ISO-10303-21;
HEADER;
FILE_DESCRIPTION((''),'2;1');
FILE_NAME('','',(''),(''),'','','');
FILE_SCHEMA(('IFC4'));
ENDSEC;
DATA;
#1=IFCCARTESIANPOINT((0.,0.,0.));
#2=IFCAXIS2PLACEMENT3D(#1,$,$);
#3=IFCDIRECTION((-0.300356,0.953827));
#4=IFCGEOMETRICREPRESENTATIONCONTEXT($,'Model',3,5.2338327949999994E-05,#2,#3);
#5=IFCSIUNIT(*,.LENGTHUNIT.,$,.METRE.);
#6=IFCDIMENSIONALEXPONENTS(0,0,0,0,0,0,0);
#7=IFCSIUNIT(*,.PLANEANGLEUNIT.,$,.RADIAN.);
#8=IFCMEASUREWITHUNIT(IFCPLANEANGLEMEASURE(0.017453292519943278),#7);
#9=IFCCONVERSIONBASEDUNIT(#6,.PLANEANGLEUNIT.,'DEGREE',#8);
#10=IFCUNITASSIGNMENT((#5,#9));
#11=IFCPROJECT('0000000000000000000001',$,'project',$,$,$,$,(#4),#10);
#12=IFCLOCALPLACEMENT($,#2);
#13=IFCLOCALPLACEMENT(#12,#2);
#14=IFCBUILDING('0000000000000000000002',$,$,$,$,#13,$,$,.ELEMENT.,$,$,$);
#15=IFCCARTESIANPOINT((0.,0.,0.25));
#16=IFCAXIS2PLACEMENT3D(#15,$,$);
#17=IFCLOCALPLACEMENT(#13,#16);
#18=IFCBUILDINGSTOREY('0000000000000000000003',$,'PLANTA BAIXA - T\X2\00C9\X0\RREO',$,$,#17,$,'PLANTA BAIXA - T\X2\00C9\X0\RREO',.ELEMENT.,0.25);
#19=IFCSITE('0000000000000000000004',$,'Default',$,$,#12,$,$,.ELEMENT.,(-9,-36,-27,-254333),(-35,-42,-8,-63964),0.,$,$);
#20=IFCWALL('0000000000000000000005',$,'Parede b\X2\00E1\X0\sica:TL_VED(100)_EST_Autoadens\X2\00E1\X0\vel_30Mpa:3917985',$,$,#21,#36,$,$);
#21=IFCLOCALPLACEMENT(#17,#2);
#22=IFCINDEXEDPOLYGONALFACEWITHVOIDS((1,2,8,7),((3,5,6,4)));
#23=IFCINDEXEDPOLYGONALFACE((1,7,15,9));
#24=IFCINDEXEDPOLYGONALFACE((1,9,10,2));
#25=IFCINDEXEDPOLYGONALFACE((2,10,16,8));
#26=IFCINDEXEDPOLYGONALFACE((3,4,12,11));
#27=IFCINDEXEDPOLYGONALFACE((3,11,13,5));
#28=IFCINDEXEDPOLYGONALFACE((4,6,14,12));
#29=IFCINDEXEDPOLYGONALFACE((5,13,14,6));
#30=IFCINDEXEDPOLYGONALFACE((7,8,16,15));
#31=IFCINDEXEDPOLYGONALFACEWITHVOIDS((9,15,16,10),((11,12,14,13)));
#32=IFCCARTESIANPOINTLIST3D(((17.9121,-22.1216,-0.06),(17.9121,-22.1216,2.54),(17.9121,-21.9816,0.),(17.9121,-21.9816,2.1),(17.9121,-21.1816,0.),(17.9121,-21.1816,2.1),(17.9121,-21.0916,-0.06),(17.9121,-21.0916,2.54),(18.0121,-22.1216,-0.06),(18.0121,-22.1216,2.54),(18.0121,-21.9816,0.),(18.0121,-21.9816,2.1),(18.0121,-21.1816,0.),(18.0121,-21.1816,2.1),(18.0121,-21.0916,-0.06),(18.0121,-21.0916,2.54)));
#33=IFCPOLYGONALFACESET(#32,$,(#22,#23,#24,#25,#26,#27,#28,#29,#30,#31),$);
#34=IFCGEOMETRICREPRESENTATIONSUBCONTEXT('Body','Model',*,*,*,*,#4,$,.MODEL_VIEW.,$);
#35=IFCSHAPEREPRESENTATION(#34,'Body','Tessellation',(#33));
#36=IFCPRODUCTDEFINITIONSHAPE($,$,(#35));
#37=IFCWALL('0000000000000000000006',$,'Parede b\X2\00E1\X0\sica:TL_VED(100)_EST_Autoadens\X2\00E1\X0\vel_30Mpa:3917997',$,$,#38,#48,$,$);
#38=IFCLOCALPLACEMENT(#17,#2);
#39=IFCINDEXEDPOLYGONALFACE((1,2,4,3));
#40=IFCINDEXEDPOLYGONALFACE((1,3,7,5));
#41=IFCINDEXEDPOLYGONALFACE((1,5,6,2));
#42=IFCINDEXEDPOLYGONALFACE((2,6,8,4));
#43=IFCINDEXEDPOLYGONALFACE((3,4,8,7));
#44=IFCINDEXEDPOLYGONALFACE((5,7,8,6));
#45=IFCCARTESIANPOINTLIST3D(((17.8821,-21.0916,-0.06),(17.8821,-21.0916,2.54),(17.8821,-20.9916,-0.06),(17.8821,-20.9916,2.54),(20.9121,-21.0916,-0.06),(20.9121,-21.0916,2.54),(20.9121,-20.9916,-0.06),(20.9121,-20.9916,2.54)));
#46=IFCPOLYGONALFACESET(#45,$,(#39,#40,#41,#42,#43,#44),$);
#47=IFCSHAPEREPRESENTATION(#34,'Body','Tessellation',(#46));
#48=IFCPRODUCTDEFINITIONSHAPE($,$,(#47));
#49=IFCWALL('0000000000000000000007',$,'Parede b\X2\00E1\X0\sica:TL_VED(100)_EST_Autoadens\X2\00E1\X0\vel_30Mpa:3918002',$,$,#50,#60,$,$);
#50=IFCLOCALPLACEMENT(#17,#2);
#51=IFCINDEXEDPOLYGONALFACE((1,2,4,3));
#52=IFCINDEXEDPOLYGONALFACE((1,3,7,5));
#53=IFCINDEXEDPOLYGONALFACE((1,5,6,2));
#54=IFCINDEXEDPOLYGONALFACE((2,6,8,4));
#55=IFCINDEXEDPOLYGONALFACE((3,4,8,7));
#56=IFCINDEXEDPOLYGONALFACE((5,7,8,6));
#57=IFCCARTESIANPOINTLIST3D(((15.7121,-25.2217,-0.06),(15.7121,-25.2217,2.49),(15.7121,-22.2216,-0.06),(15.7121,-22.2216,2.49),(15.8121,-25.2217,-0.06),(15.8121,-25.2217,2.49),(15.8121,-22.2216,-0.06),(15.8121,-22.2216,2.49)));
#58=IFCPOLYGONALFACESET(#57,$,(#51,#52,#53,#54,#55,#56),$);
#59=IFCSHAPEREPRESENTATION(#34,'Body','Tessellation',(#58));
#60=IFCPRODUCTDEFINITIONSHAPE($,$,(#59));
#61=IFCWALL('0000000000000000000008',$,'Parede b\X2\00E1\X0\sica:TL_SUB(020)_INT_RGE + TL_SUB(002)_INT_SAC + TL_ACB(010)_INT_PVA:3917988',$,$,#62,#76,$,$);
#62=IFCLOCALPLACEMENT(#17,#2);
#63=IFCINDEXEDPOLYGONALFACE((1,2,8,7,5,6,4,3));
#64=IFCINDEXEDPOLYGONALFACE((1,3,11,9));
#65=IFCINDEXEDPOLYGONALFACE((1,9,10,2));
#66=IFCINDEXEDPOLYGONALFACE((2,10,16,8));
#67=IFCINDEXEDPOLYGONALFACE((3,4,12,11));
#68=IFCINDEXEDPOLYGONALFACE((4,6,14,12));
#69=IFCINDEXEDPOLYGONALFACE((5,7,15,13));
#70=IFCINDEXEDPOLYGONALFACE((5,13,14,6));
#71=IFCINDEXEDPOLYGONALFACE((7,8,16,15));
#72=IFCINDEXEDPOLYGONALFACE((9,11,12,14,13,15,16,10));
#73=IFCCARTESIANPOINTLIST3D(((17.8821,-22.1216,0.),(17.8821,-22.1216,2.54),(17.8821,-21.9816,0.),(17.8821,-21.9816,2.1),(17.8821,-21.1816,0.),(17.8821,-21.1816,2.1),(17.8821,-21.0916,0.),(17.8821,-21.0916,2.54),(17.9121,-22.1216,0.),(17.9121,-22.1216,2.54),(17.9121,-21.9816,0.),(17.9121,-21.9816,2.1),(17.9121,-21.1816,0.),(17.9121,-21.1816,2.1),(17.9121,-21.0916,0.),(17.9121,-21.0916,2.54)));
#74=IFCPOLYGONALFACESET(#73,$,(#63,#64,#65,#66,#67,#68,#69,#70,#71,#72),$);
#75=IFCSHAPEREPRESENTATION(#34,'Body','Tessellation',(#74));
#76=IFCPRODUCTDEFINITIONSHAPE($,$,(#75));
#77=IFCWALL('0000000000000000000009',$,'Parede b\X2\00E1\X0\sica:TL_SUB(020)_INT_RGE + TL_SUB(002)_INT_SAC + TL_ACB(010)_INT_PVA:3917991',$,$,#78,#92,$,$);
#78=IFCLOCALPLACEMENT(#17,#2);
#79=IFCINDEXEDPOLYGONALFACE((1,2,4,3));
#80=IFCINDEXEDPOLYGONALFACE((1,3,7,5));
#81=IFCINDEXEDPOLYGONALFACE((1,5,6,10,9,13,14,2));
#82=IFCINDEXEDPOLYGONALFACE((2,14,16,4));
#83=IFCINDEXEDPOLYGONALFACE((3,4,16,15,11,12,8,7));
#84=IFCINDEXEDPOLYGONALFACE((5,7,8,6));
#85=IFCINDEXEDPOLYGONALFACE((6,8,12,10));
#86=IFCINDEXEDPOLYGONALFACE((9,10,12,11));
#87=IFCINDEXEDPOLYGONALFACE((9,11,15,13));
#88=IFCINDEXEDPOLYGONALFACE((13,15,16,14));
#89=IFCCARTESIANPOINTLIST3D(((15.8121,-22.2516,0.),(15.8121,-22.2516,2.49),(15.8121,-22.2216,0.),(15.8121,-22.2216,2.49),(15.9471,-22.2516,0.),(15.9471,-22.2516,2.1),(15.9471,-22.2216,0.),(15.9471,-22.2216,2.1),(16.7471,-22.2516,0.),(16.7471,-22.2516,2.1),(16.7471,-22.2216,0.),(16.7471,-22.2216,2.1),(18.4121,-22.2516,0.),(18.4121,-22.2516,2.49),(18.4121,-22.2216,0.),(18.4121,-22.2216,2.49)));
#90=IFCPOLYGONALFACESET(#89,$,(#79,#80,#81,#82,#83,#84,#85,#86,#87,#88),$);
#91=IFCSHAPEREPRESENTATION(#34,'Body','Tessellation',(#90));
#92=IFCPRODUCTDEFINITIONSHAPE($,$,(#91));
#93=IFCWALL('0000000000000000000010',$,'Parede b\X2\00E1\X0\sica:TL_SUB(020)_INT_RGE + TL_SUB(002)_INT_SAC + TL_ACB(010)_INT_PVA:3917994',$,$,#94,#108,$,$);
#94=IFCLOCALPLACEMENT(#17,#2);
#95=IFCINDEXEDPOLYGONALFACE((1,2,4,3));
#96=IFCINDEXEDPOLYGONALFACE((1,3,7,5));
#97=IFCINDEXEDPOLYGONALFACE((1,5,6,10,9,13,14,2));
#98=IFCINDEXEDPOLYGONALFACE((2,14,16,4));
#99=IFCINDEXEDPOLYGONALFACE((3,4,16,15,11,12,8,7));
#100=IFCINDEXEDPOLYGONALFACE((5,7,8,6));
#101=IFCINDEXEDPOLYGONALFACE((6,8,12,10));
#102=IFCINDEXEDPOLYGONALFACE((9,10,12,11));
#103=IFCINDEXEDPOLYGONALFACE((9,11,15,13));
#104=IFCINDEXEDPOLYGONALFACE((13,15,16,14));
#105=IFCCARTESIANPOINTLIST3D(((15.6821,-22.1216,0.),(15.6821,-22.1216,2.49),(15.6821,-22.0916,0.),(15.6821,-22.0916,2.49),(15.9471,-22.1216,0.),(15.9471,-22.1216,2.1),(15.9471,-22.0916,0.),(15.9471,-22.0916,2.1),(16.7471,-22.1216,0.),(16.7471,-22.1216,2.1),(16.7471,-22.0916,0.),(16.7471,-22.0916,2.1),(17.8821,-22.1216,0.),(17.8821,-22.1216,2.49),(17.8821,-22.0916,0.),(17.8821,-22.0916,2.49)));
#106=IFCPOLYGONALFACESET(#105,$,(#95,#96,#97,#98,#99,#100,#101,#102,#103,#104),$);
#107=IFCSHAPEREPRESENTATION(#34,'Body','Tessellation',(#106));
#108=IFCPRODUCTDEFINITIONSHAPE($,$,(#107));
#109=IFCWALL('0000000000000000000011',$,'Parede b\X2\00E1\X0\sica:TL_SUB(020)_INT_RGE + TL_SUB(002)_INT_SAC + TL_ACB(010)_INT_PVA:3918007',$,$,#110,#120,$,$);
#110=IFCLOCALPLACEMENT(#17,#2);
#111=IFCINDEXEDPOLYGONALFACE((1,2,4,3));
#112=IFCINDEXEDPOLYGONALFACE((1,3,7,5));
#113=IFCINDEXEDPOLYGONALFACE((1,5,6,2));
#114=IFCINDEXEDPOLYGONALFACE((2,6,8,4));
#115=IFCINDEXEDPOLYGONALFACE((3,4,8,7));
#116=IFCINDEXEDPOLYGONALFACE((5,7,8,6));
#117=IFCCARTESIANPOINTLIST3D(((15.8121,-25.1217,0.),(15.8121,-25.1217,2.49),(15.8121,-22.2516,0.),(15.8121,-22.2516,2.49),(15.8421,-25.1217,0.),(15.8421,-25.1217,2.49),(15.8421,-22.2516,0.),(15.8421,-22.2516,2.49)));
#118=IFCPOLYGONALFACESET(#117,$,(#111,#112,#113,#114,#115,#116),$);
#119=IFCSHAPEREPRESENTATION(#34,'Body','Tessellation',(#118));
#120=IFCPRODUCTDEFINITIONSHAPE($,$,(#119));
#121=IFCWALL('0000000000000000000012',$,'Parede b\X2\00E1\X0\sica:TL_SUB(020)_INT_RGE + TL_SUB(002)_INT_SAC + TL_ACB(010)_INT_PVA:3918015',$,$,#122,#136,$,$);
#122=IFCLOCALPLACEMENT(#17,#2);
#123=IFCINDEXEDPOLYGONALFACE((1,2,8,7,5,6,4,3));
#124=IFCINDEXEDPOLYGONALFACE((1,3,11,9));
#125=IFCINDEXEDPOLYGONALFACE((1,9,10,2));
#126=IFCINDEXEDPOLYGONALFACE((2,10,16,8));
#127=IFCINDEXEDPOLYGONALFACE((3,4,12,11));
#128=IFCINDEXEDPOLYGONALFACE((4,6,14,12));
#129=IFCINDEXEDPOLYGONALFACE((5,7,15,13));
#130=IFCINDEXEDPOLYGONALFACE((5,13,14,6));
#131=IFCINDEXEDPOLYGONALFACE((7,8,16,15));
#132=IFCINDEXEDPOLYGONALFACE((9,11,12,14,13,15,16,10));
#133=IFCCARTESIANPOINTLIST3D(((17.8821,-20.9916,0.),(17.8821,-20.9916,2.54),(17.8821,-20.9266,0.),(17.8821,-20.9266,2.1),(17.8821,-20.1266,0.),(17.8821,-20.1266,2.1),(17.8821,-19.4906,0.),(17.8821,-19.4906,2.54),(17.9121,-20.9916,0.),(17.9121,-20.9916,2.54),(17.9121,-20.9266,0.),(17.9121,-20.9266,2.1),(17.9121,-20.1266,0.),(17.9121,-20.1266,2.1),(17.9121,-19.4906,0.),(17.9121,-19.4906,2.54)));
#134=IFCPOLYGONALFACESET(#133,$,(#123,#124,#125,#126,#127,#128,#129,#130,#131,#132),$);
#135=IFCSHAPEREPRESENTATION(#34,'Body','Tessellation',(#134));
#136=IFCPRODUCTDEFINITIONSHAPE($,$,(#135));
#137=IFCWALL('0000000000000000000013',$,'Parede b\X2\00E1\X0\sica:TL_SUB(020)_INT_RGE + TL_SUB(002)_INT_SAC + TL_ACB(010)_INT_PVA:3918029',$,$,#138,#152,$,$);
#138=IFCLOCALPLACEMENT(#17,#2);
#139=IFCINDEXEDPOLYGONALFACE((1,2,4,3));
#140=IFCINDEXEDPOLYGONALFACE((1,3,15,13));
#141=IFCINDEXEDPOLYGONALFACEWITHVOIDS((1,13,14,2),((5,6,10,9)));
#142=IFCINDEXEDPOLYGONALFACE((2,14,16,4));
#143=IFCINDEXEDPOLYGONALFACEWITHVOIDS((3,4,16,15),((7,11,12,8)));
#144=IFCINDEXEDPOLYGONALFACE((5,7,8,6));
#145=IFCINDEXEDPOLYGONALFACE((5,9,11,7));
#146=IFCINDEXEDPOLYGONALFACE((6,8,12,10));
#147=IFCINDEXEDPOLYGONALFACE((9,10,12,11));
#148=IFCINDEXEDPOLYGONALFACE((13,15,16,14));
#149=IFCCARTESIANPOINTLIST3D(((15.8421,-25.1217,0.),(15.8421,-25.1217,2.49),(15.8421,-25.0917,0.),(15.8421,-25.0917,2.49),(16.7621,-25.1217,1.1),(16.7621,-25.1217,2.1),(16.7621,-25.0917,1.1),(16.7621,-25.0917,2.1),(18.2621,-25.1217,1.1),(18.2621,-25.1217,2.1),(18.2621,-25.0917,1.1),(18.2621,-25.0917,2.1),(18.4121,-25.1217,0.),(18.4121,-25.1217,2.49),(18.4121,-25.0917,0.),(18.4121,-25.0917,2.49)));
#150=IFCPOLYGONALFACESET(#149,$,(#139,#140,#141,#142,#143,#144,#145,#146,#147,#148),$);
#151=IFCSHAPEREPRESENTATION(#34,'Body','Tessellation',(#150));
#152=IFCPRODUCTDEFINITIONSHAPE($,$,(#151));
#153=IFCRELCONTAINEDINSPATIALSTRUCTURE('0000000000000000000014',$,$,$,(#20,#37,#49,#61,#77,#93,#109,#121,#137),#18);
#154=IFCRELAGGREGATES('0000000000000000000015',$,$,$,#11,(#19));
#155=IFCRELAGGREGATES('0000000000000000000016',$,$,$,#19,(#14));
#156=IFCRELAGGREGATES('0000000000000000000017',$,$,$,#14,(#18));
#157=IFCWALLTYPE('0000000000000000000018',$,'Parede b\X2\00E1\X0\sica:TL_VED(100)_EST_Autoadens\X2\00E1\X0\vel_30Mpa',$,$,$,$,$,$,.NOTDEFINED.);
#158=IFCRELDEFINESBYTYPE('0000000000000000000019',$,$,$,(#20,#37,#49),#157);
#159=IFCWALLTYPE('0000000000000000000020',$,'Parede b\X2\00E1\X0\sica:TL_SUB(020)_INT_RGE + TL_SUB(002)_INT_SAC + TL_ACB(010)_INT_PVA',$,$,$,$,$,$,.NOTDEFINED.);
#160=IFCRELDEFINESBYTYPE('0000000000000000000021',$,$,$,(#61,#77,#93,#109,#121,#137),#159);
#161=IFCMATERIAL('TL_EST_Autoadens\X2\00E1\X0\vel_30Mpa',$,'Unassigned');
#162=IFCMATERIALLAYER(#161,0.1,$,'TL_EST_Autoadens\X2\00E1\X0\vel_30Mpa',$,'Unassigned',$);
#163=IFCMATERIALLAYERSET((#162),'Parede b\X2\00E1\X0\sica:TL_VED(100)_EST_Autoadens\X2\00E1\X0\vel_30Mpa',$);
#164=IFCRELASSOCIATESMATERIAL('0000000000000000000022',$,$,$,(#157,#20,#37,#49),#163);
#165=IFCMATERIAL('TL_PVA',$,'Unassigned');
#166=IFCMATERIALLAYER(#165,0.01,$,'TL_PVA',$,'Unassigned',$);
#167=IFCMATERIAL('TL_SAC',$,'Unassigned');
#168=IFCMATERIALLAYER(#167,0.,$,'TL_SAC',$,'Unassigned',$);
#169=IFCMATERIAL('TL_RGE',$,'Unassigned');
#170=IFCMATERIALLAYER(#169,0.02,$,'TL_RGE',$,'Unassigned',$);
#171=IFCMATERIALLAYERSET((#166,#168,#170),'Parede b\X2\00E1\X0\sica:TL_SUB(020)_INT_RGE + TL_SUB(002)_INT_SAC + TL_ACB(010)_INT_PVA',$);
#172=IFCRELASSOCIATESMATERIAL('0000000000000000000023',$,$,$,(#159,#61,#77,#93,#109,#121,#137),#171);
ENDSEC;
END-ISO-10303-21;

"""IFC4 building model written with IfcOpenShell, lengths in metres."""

from ifc_helpers import new_model, entity, si_unit, converted_unit, direction, frame, frame_2d, origin, place, context, subcontext, project, spatial, rectangle, extrude, material, layer, layer_set, layer_usage, type_object, element, save


model = new_model("IFC4")

# Units and contexts
model_context = context("Model", 3, precision=5.2338327949999994e-05, world=origin(), true_north=direction((-0.300356, 0.953827)))
body_context = subcontext(model_context, "Body", "Model", "MODEL_VIEW")
ifc_project = project(units=[si_unit("LENGTHUNIT", "METRE"), converted_unit("PLANEANGLEUNIT", "DEGREE", entity("IfcPlaneAngleMeasure", 0.017453292519943278), si_unit("PLANEANGLEUNIT", "RADIAN"), dimensions=[0, 0, 0, 0, 0, 0, 0])], contexts=[model_context])

# Site, building, storey
site_placement = place(None, origin())
site = spatial("IfcSite", under=ifc_project, at=site_placement, Name="Default", CompositionType="ELEMENT", RefLatitude=(-9, -36, -27, -254333), RefLongitude=(-35, -42, -8, -63964), RefElevation=0.0)
building_placement = place(site_placement, origin())
building = spatial("IfcBuilding", under=site, at=building_placement, CompositionType="ELEMENT")
storey_placement = place(building_placement, frame((0.0, 0.0, 0.25)))
storey = spatial("IfcBuildingStorey", under=building, at=storey_placement, Name="PLANTA BAIXA - TÉRREO", LongName="PLANTA BAIXA - TÉRREO", CompositionType="ELEMENT", Elevation=0.25)

# Wall, opening
ifc_material_1 = material(Name="TL_EST_Autoadensável_30Mpa", Category="Unassigned")
ifc_layer_1 = layer(ifc_material_1, 0.1, Name="TL_EST_Autoadensável_30Mpa", Category="Unassigned")
ifc_layer_set_1 = layer_set([ifc_layer_1], Name="Parede básica:TL_VED(100)_EST_Autoadensável_30Mpa")
ifc_layer_usage_1 = layer_usage(ifc_layer_set_1, "AXIS2", "POSITIVE", -0.05)
wall_type_1 = type_object("IfcWallType", Name="Parede básica:TL_VED(100)_EST_Autoadensável_30Mpa", PredefinedType="NOTDEFINED", material=ifc_layer_set_1)
wall_1_placement = place(storey_placement, frame((17.9621, -22.1216, -0.06), z_axis=(0.0, 0.0, 1.0), x_axis=(0.0, 1.0, 0.0)))
wall_1 = element("IfcWall", 1, at=wall_1_placement, inside=storey, type_object=wall_type_1, material=ifc_layer_usage_1, Name="Parede básica:TL_VED(100)_EST_Autoadensável_30Mpa:3917985", context=body_context, shape_type="SweptSolid", body=[
    extrude(rectangle(XDim=1.03, YDim=0.1, at=frame_2d((0.515, 0.0), x_axis=(-1.0, 0.0))), origin(), (0.0, 0.0, 1.0), 2.6),
])
opening_1_placement = place(wall_1_placement, frame((0.94, 0.05, 0.06)))
element("IfcOpeningElement", 2, at=opening_1_placement, cuts=wall_1, PredefinedType="OPENING", context=body_context, shape_type="SweptSolid", body=[
    extrude(rectangle(XDim=2.1, YDim=0.8, at=frame_2d((1.05, 0.4), x_axis=(1.0, 0.0))), frame((0.0, 0.0, 0.0), z_axis=(0.0, -1.0, 0.0), x_axis=(0.0, 0.0, 1.0)), (0.0, 0.0, 1.0), 0.1),
])

# Wall
ifc_layer_usage_2 = layer_usage(ifc_layer_set_1, "AXIS2", "NEGATIVE", 0.05)
wall_2_placement = place(storey_placement, frame((17.8821, -21.0416, -0.06)))
element("IfcWall", 3, at=wall_2_placement, inside=storey, type_object=wall_type_1, material=ifc_layer_usage_2, Name="Parede básica:TL_VED(100)_EST_Autoadensável_30Mpa:3917997", context=body_context, shape_type="SweptSolid", body=[
    extrude(rectangle(XDim=3.03, YDim=0.1, at=frame_2d((1.515, 0.0), x_axis=(-1.0, 0.0))), origin(), (0.0, 0.0, 1.0), 2.6),
])

# Walls, openings
ifc_layer_usage_3 = layer_usage(ifc_layer_set_1, "AXIS2", "NEGATIVE", 0.05)
wall_3_placement = place(storey_placement, frame((15.7621, -25.2217, -0.06), z_axis=(0.0, 0.0, 1.0), x_axis=(0.0, 1.0, 0.0)))
wall_3 = element("IfcWall", 4, at=wall_3_placement, inside=storey, type_object=wall_type_1, material=ifc_layer_usage_3, Name="Parede básica:TL_VED(100)_EST_Autoadensável_30Mpa:3918002", context=body_context, shape_type="SweptSolid", body=[
    extrude(rectangle(XDim=3.0001, YDim=0.1, at=frame_2d((1.5001, 0.0), x_axis=(-1.0, 0.0))), origin(), (0.0, 0.0, 1.0), 2.55),
])
opening_2_placement = place(wall_3_placement, frame((25.2217, 15.7621, 0.06)))
element("IfcOpeningElement", 5, at=opening_2_placement, cuts=wall_3, PredefinedType="OPENING", context=body_context, shape_type="SweptSolid", body=[
    extrude(rectangle(XDim=2.1, YDim=0.1, at=frame_2d((0.0, 0.0), x_axis=(0.0, 1.0))), frame((-24.2717, -15.7121, 1.05), z_axis=(0.0, 1.0, 0.0), x_axis=(1.0, 0.0, 0.0)), (0.0, 0.0, 1.0), 2.4),
])
ifc_material_2 = material(Name="TL_PVA", Category="Unassigned")
ifc_layer_2 = layer(ifc_material_2, 0.01, Name="TL_PVA", Category="Unassigned")
ifc_material_3 = material(Name="TL_SAC", Category="Unassigned")
ifc_layer_3 = layer(ifc_material_3, 0.0, Name="TL_SAC", Category="Unassigned")
ifc_material_4 = material(Name="TL_RGE", Category="Unassigned")
ifc_layer_4 = layer(ifc_material_4, 0.02, Name="TL_RGE", Category="Unassigned")
ifc_layer_set_2 = layer_set([ifc_layer_2, ifc_layer_3, ifc_layer_4], Name="Parede básica:TL_SUB(020)_INT_RGE + TL_SUB(002)_INT_SAC + TL_ACB(010)_INT_PVA")
ifc_layer_usage_4 = layer_usage(ifc_layer_set_2, "AXIS2", "POSITIVE", -0.015)
wall_type_2 = type_object("IfcWallType", Name="Parede básica:TL_SUB(020)_INT_RGE + TL_SUB(002)_INT_SAC + TL_ACB(010)_INT_PVA", PredefinedType="NOTDEFINED", material=ifc_layer_set_2)
wall_4_placement = place(storey_placement, frame((17.8971, -21.0916, 0.0), z_axis=(0.0, 0.0, 1.0), x_axis=(0.0, -1.0, 0.0)))
wall_4 = element("IfcWall", 6, at=wall_4_placement, inside=storey, type_object=wall_type_2, material=ifc_layer_usage_4, Name="Parede básica:TL_SUB(020)_INT_RGE + TL_SUB(002)_INT_SAC + TL_ACB(010)_INT_PVA:3917988", context=body_context, shape_type="SweptSolid", body=[
    extrude(rectangle(XDim=1.03, YDim=0.03, at=frame_2d((0.515, 0.0), x_axis=(-1.0, 0.0))), origin(), (0.0, 0.0, 1.0), 2.54),
])
opening_3_placement = place(wall_4_placement, frame((-21.0916, -17.8971, 0.0)))
element("IfcOpeningElement", 7, at=opening_3_placement, cuts=wall_4, PredefinedType="OPENING", context=body_context, shape_type="SweptSolid", body=[
    extrude(rectangle(XDim=2.1, YDim=0.8, at=frame_2d((0.0, 0.0), x_axis=(1.0, 0.0))), frame((21.5816, 16.3881, 1.05), z_axis=(0.0, 1.0, 0.0), x_axis=(0.0, 0.0, 1.0)), (0.0, 0.0, 1.0), 3.048),
])
ifc_layer_usage_5 = layer_usage(ifc_layer_set_2, "AXIS2", "POSITIVE", -0.015)
wall_5_placement = place(storey_placement, frame((15.8121, -22.2366, 0.0)))
wall_5 = element("IfcWall", 8, at=wall_5_placement, inside=storey, type_object=wall_type_2, material=ifc_layer_usage_5, Name="Parede básica:TL_SUB(020)_INT_RGE + TL_SUB(002)_INT_SAC + TL_ACB(010)_INT_PVA:3917991", context=body_context, shape_type="SweptSolid", body=[
    extrude(rectangle(XDim=2.6, YDim=0.03, at=frame_2d((1.3, 0.0), x_axis=(-1.0, 0.0))), origin(), (0.0, 0.0, 1.0), 2.49),
])
opening_4_placement = place(wall_5_placement, frame((-15.8121, 22.2366, 0.0)))
element("IfcOpeningElement", 9, at=opening_4_placement, cuts=wall_5, PredefinedType="OPENING", context=body_context, shape_type="SweptSolid", body=[
    extrude(rectangle(XDim=2.1, YDim=0.8, at=frame_2d((0.0, 0.0), x_axis=(1.0, 0.0))), frame((16.3471, -23.6456, 1.05), z_axis=(0.0, 1.0, 0.0), x_axis=(0.0, 0.0, 1.0)), (0.0, 0.0, 1.0), 3.048),
])
ifc_layer_usage_6 = layer_usage(ifc_layer_set_2, "AXIS2", "POSITIVE", -0.015)
wall_6_placement = place(storey_placement, frame((17.8821, -22.1066, 0.0), z_axis=(0.0, 0.0, 1.0), x_axis=(-1.0, 0.0, 0.0)))
wall_6 = element("IfcWall", 10, at=wall_6_placement, inside=storey, type_object=wall_type_2, material=ifc_layer_usage_6, Name="Parede básica:TL_SUB(020)_INT_RGE + TL_SUB(002)_INT_SAC + TL_ACB(010)_INT_PVA:3917994", context=body_context, shape_type="SweptSolid", body=[
    extrude(rectangle(XDim=2.2, YDim=0.03, at=frame_2d((1.1, 0.0), x_axis=(1.0, 0.0))), origin(), (0.0, 0.0, 1.0), 2.49),
])
opening_5_placement = place(wall_6_placement, frame((17.8821, -22.1066, 0.0)))
element("IfcOpeningElement", 11, at=opening_5_placement, cuts=wall_6, PredefinedType="OPENING", context=body_context, shape_type="SweptSolid", body=[
    extrude(rectangle(XDim=2.1, YDim=0.8, at=frame_2d((0.0, 0.0), x_axis=(0.0, 1.0))), frame((-16.3471, 20.5976, 1.05), z_axis=(0.0, 1.0, 0.0), x_axis=(-1.0, 0.0, 0.0)), (0.0, 0.0, 1.0), 3.048),
])

# Wall
ifc_layer_usage_7 = layer_usage(ifc_layer_set_2, "AXIS2", "NEGATIVE", 0.015)
wall_7_placement = place(storey_placement, frame((15.8271, -22.2516, 0.0), z_axis=(0.0, 0.0, 1.0), x_axis=(0.0, -1.0, 0.0)))
element("IfcWall", 12, at=wall_7_placement, inside=storey, type_object=wall_type_2, material=ifc_layer_usage_7, Name="Parede básica:TL_SUB(020)_INT_RGE + TL_SUB(002)_INT_SAC + TL_ACB(010)_INT_PVA:3918007", context=body_context, shape_type="SweptSolid", body=[
    extrude(rectangle(XDim=2.8701, YDim=0.03, at=frame_2d((1.4351, 0.0), x_axis=(-1.0, 0.0))), origin(), (0.0, 0.0, 1.0), 2.49),
])

# Walls, openings
ifc_layer_usage_8 = layer_usage(ifc_layer_set_2, "AXIS2", "NEGATIVE", 0.015)
wall_8_placement = place(storey_placement, frame((17.8971, -20.9916, 0.0), z_axis=(0.0, 0.0, 1.0), x_axis=(0.0, 1.0, 0.0)))
wall_8 = element("IfcWall", 13, at=wall_8_placement, inside=storey, type_object=wall_type_2, material=ifc_layer_usage_8, Name="Parede básica:TL_SUB(020)_INT_RGE + TL_SUB(002)_INT_SAC + TL_ACB(010)_INT_PVA:3918015", context=body_context, shape_type="SweptSolid", body=[
    extrude(rectangle(XDim=1.501, YDim=0.03, at=frame_2d((0.7505, 0.0), x_axis=(-1.0, 0.0))), origin(), (0.0, 0.0, 1.0), 2.54),
])
opening_6_placement = place(wall_8_placement, frame((0.865, 0.015, 0.0)))
element("IfcOpeningElement", 14, at=opening_6_placement, cuts=wall_8, PredefinedType="OPENING", context=body_context, shape_type="SweptSolid", body=[
    extrude(rectangle(XDim=2.1, YDim=0.8, at=frame_2d((1.05, 0.4), x_axis=(1.0, 0.0))), frame((0.0, 0.0, 0.0), z_axis=(0.0, -1.0, 0.0), x_axis=(0.0, 0.0, 1.0)), (0.0, 0.0, 1.0), 0.03),
])
ifc_layer_usage_9 = layer_usage(ifc_layer_set_2, "AXIS2", "NEGATIVE", 0.015)
wall_9_placement = place(storey_placement, frame((15.8421, -25.1067, 0.0)))
wall_9 = element("IfcWall", 15, at=wall_9_placement, inside=storey, type_object=wall_type_2, material=ifc_layer_usage_9, Name="Parede básica:TL_SUB(020)_INT_RGE + TL_SUB(002)_INT_SAC + TL_ACB(010)_INT_PVA:3918029", context=body_context, shape_type="SweptSolid", body=[
    extrude(rectangle(XDim=2.57, YDim=0.03, at=frame_2d((1.285, 0.0), x_axis=(-1.0, 0.0))), origin(), (0.0, 0.0, 1.0), 2.49),
])
opening_7_placement = place(wall_9_placement, frame((-15.8421, 25.1067, 1.1)))
element("IfcOpeningElement", 16, at=opening_7_placement, cuts=wall_9, PredefinedType="OPENING", context=body_context, shape_type="SweptSolid", body=[
    extrude(rectangle(XDim=1.0, YDim=1.5, at=frame_2d((0.0, 0.0), x_axis=(0.0, 1.0))), frame((17.5121, -26.6457, 0.5), z_axis=(0.0, 1.0, 0.0), x_axis=(1.0, 0.0, 0.0)), (0.0, 0.0, 1.0), 3.048),
])

save(model, "model.ifc")
